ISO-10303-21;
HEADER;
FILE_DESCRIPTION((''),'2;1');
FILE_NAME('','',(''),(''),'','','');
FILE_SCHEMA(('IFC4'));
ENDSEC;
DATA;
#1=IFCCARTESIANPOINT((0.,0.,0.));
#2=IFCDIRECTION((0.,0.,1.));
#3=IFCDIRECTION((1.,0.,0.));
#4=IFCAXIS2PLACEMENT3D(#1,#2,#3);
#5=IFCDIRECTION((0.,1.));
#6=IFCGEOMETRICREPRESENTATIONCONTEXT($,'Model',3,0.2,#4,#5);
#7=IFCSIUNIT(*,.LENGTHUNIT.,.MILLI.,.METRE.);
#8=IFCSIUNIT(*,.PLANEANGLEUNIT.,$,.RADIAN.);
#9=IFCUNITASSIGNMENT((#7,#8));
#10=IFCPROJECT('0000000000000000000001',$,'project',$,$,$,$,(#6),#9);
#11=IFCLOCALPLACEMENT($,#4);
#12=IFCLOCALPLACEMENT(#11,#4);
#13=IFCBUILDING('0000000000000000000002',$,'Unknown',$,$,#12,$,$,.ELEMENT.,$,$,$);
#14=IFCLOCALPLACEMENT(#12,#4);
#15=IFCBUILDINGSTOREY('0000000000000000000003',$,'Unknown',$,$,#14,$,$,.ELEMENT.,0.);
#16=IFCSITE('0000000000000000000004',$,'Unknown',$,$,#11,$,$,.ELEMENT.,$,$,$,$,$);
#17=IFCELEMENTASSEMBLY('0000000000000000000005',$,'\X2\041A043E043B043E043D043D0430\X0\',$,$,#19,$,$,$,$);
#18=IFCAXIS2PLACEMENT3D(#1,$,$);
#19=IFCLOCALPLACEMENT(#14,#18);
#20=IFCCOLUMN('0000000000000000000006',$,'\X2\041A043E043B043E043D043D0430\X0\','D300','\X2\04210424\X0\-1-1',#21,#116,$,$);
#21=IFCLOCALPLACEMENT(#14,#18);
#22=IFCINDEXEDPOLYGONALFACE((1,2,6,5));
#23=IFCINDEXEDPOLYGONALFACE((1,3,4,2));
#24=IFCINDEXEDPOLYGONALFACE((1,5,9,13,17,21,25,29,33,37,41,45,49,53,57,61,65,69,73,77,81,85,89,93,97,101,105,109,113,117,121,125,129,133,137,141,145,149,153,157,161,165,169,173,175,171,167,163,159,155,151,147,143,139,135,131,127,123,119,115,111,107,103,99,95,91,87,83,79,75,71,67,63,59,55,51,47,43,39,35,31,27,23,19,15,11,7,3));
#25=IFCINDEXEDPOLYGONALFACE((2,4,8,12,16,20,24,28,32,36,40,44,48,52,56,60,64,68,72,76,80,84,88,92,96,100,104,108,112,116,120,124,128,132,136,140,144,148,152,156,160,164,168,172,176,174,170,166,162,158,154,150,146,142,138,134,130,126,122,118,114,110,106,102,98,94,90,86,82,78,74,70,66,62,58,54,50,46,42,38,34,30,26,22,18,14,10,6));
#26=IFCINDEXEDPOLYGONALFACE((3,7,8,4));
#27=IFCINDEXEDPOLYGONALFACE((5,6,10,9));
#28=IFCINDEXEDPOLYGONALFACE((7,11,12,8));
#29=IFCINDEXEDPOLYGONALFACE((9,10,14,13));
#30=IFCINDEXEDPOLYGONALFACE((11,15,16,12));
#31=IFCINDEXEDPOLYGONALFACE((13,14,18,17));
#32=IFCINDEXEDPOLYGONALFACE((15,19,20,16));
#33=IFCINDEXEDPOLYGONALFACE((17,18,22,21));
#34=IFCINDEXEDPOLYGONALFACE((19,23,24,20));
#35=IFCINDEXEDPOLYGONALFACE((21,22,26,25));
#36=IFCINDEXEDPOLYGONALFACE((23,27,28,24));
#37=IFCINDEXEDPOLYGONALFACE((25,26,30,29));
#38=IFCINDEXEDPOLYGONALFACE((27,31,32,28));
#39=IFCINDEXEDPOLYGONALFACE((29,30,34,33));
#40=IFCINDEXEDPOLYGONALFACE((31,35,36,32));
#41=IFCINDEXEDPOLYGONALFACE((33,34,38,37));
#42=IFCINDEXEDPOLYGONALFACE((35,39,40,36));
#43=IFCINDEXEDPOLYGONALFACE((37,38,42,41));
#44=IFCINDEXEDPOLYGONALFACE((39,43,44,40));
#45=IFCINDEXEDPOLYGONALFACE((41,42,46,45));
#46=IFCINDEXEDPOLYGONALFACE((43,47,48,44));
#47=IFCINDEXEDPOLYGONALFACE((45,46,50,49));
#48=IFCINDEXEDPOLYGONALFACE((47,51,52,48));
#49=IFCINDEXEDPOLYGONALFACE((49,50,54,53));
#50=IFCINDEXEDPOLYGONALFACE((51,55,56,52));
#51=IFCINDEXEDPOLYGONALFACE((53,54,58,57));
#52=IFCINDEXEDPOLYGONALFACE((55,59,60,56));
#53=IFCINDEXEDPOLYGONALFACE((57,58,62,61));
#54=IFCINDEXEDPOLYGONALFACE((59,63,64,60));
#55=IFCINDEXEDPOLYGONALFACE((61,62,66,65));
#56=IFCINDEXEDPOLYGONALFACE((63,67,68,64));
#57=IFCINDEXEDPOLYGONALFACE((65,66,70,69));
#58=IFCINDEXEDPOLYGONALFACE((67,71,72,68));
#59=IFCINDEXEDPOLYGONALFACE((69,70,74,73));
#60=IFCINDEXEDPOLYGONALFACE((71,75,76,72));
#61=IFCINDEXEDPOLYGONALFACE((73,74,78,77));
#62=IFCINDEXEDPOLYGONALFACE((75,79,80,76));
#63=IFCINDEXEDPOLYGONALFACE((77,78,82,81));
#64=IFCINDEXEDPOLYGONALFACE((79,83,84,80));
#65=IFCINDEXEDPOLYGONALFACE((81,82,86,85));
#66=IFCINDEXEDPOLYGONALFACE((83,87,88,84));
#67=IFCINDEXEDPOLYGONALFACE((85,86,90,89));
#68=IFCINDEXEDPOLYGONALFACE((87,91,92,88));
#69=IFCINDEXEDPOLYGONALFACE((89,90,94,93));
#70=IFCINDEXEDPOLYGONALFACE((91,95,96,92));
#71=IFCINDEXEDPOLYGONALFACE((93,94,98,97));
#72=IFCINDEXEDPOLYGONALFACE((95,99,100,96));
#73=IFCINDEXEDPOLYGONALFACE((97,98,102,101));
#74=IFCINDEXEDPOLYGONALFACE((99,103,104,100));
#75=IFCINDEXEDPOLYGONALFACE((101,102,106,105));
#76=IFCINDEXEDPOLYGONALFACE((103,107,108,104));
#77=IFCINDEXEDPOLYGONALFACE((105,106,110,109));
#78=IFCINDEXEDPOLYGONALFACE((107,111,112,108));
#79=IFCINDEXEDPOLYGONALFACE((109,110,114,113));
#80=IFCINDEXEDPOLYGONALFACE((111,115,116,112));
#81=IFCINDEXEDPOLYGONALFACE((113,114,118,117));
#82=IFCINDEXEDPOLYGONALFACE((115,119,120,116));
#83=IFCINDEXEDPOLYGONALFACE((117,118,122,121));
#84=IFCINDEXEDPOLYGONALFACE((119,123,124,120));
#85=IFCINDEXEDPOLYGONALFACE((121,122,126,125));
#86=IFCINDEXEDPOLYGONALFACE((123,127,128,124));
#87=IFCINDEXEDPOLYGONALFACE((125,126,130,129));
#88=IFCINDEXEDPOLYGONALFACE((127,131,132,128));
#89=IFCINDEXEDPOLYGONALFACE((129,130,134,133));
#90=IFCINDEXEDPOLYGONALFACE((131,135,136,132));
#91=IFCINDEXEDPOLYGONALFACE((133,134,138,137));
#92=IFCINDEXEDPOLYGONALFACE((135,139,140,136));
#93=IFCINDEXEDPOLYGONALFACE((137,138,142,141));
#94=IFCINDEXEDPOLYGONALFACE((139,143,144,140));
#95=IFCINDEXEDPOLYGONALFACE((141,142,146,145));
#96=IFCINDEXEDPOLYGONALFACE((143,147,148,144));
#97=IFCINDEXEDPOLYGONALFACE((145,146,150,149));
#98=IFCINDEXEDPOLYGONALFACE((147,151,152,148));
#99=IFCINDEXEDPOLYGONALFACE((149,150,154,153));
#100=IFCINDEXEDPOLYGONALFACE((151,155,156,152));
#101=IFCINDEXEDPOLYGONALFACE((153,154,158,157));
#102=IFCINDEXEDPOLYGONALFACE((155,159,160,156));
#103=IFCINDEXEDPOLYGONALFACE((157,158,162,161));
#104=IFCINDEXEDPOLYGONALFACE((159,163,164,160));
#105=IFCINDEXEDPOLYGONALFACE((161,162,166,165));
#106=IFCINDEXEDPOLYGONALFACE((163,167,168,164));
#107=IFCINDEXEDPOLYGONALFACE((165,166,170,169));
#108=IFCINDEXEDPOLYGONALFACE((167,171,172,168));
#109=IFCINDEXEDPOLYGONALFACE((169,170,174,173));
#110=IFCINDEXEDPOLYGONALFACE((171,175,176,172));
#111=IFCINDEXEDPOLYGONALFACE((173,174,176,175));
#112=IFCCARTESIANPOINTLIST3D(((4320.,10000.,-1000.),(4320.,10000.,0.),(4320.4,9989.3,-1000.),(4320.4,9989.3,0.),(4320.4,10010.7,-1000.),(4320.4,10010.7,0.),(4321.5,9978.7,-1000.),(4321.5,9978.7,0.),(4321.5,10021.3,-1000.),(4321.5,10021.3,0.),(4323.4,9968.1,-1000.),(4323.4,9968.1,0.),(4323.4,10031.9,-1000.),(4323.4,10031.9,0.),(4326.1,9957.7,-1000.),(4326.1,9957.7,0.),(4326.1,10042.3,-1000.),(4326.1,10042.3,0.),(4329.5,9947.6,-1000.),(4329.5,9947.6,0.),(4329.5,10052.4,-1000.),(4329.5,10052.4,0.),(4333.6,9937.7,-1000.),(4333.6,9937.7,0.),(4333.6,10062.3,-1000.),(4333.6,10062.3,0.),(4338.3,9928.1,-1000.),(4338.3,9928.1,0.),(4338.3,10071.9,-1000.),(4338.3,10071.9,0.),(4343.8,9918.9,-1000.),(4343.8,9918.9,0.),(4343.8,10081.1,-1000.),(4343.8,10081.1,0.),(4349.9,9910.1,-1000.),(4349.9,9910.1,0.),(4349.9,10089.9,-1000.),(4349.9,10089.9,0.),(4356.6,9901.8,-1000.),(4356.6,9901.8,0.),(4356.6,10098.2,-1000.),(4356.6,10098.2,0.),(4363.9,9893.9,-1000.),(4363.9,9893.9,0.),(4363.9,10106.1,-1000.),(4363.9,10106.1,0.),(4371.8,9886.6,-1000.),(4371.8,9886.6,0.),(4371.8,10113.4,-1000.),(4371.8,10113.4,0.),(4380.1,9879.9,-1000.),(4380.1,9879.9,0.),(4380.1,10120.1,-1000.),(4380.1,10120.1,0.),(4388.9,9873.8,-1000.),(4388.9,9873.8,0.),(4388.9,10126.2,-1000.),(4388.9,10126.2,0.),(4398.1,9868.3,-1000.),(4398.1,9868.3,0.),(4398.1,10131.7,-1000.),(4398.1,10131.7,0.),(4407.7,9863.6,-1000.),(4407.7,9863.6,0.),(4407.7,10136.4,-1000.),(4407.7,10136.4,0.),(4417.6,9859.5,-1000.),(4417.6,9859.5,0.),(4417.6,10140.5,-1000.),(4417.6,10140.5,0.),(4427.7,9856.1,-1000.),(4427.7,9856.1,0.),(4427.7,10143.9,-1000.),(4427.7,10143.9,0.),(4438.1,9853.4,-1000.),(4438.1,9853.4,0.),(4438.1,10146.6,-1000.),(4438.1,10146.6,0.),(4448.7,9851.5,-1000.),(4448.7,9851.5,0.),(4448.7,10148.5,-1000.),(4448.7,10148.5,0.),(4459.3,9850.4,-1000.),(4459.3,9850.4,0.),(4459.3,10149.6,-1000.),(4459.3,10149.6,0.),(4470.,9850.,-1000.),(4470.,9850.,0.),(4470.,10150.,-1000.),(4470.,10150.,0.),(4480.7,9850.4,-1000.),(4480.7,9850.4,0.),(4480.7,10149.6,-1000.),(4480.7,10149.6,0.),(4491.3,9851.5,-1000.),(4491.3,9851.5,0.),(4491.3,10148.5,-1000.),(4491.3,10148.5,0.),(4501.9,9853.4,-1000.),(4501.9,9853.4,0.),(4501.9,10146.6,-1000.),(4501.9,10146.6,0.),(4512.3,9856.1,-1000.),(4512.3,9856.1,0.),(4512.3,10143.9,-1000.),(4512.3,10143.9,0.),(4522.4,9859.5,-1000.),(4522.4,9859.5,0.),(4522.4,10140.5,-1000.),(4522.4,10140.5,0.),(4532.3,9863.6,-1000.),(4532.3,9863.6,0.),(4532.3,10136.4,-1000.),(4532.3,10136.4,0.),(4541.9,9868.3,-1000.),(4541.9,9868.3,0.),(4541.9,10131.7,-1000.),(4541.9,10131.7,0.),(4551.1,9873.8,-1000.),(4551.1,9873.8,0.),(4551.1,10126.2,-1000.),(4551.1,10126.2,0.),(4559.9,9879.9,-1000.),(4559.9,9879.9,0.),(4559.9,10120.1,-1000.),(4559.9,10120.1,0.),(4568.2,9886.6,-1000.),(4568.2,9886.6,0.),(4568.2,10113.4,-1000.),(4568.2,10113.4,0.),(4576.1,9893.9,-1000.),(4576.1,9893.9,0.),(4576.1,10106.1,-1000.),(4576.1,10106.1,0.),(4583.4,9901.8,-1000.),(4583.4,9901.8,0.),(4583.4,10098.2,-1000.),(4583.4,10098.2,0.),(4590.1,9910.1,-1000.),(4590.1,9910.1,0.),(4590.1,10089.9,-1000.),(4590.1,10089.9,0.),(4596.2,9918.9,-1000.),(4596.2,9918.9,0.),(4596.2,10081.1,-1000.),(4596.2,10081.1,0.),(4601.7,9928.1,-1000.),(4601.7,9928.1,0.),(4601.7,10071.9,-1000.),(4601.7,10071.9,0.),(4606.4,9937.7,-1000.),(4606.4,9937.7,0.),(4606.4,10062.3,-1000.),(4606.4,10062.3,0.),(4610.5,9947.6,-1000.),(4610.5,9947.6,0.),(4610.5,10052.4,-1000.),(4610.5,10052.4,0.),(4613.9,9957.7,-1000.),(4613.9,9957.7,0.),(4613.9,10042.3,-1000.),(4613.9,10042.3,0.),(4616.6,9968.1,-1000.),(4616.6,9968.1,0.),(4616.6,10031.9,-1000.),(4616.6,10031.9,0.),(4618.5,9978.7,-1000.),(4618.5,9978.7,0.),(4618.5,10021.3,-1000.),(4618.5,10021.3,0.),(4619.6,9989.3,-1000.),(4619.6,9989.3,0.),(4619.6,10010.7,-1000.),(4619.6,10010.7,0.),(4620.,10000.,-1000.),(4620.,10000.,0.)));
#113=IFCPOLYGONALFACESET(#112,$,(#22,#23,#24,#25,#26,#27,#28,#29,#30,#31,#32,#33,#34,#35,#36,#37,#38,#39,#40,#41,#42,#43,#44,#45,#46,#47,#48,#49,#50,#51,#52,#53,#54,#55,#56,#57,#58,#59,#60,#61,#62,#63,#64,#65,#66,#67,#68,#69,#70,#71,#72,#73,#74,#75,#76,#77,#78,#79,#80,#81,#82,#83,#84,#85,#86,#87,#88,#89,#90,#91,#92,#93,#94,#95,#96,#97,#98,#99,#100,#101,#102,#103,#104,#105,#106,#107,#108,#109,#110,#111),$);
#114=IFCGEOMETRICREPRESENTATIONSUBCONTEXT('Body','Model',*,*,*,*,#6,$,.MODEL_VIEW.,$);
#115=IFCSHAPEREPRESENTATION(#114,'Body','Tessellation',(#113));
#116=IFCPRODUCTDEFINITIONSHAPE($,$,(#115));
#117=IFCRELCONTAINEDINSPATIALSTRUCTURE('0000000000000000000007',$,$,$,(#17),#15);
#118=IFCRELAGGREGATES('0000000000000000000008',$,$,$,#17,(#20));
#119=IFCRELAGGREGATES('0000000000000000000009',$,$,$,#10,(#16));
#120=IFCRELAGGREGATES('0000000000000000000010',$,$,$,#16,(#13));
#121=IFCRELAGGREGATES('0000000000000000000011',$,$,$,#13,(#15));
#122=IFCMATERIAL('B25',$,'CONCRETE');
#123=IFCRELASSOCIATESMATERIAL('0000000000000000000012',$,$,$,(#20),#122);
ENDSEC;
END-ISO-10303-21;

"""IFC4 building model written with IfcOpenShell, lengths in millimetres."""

from ifc_helpers import new_model, si_unit, direction, frame, origin_with_axes, place, context, subcontext, project, spatial, line, indexed_curve, outline, extrude, material, element, aggregate, save


model = new_model("IFC4")

# Units and contexts
model_context = context("Model", 3, precision=0.2, world=origin_with_axes(), true_north=direction((0.0, 1.0)))
body_context = subcontext(model_context, "Body", "Model", "MODEL_VIEW")
ifc_project = project(units=[si_unit("LENGTHUNIT", "METRE", prefix="MILLI"), si_unit("PLANEANGLEUNIT", "RADIAN")], contexts=[model_context])

# Site, building, storey
site_placement = place(None, origin_with_axes())
site = spatial("IfcSite", under=ifc_project, at=site_placement, Name="Unknown", CompositionType="ELEMENT")
building_placement = place(site_placement, origin_with_axes())
building = spatial("IfcBuilding", under=site, at=building_placement, Name="Unknown", CompositionType="ELEMENT")
storey_placement = place(building_placement, origin_with_axes())
storey = spatial("IfcBuildingStorey", under=building, at=storey_placement, Name="Unknown", CompositionType="ELEMENT", Elevation=0.0)

# Element assembly, column
assembly_1_placement = place(storey_placement, frame((4470.0, 10000.0, -1000.0), z_axis=(-1.0, 0.0, 0.0), x_axis=(0.0, 0.0, 1.0)))
assembly_1 = element("IfcElementAssembly", 1, at=assembly_1_placement, inside=storey, Name="Колонна")
ifc_material_1 = material(Name="B25", Category="CONCRETE")
column_1_placement = place(assembly_1_placement, origin_with_axes())
column_1 = element("IfcColumn", 2, at=column_1_placement, material=ifc_material_1, Name="Колонна", Description="D300", ObjectType="СФ-1-1", context=body_context, shape_type="SolidModel", body=[
    extrude(outline(indexed_curve([(150.0, 0.0), (149.6, 10.7), (148.5, 21.3), (146.6, 31.9), (143.9, 42.3), (140.5, 52.4), (136.4, 62.3), (131.7, 71.9), (126.2, 81.1), (120.1, 89.9), (113.4, 98.2), (106.1, 106.1), (98.2, 113.4), (89.9, 120.1), (81.1, 126.2), (71.9, 131.7), (62.3, 136.4), (52.4, 140.5), (42.3, 143.9), (31.9, 146.6), (21.3, 148.5), (10.7, 149.6), (0.0, 150.0), (-10.7, 149.6), (-21.3, 148.5), (-31.9, 146.6), (-42.3, 143.9), (-52.4, 140.5), (-62.3, 136.4), (-71.9, 131.7), (-81.1, 126.2), (-89.9, 120.1), (-98.2, 113.4), (-106.1, 106.1), (-113.4, 98.2), (-120.1, 89.9), (-126.2, 81.1), (-131.7, 71.9), (-136.4, 62.3), (-140.5, 52.4), (-143.9, 42.3), (-146.6, 31.9), (-148.5, 21.3), (-149.6, 10.7), (-150.0, 0.0), (-149.6, -10.7), (-148.5, -21.3), (-146.6, -31.9), (-143.9, -42.3), (-140.5, -52.4), (-136.4, -62.3), (-131.7, -71.9), (-126.2, -81.1), (-120.1, -89.9), (-113.4, -98.2), (-106.1, -106.1), (-98.2, -113.4), (-89.9, -120.1), (-81.1, -126.2), (-71.9, -131.7), (-62.3, -136.4), (-52.4, -140.5), (-42.3, -143.9), (-31.9, -146.6), (-21.3, -148.5), (-10.7, -149.6), (0.0, -150.0), (10.7, -149.6), (21.3, -148.5), (31.9, -146.6), (42.3, -143.9), (52.4, -140.5), (62.3, -136.4), (71.9, -131.7), (81.1, -126.2), (89.9, -120.1), (98.2, -113.4), (106.1, -106.1), (113.4, -98.2), (120.1, -89.9), (126.2, -81.1), (131.7, -71.9), (136.4, -62.3), (140.5, -52.4), (143.9, -42.3), (146.6, -31.9), (148.5, -21.3), (149.6, -10.7)], segments=[line(1, 2, 3, 4, 5, 6, 7, 8, 9, 10, 11, 12, 13, 14, 15, 16, 17, 18, 19, 20, 21, 22, 23, 24, 25, 26, 27, 28, 29, 30, 31, 32, 33, 34, 35, 36, 37, 38, 39, 40, 41, 42, 43, 44, 45, 46, 47, 48, 49, 50, 51, 52, 53, 54, 55, 56, 57, 58, 59, 60, 61, 62, 63, 64, 65, 66, 67, 68, 69, 70, 71, 72, 73, 74, 75, 76, 77, 78, 79, 80, 81, 82, 83, 84, 85, 86, 87, 88, 1)])), frame((0.0, 0.0, 0.0), z_axis=(-1.0, 0.0, 0.0), x_axis=(0.0, 0.0, 1.0)), (0.0, 0.0, -1.0), 1000.0),
])
aggregate(assembly_1, [column_1])

save(model, "model.ifc")
